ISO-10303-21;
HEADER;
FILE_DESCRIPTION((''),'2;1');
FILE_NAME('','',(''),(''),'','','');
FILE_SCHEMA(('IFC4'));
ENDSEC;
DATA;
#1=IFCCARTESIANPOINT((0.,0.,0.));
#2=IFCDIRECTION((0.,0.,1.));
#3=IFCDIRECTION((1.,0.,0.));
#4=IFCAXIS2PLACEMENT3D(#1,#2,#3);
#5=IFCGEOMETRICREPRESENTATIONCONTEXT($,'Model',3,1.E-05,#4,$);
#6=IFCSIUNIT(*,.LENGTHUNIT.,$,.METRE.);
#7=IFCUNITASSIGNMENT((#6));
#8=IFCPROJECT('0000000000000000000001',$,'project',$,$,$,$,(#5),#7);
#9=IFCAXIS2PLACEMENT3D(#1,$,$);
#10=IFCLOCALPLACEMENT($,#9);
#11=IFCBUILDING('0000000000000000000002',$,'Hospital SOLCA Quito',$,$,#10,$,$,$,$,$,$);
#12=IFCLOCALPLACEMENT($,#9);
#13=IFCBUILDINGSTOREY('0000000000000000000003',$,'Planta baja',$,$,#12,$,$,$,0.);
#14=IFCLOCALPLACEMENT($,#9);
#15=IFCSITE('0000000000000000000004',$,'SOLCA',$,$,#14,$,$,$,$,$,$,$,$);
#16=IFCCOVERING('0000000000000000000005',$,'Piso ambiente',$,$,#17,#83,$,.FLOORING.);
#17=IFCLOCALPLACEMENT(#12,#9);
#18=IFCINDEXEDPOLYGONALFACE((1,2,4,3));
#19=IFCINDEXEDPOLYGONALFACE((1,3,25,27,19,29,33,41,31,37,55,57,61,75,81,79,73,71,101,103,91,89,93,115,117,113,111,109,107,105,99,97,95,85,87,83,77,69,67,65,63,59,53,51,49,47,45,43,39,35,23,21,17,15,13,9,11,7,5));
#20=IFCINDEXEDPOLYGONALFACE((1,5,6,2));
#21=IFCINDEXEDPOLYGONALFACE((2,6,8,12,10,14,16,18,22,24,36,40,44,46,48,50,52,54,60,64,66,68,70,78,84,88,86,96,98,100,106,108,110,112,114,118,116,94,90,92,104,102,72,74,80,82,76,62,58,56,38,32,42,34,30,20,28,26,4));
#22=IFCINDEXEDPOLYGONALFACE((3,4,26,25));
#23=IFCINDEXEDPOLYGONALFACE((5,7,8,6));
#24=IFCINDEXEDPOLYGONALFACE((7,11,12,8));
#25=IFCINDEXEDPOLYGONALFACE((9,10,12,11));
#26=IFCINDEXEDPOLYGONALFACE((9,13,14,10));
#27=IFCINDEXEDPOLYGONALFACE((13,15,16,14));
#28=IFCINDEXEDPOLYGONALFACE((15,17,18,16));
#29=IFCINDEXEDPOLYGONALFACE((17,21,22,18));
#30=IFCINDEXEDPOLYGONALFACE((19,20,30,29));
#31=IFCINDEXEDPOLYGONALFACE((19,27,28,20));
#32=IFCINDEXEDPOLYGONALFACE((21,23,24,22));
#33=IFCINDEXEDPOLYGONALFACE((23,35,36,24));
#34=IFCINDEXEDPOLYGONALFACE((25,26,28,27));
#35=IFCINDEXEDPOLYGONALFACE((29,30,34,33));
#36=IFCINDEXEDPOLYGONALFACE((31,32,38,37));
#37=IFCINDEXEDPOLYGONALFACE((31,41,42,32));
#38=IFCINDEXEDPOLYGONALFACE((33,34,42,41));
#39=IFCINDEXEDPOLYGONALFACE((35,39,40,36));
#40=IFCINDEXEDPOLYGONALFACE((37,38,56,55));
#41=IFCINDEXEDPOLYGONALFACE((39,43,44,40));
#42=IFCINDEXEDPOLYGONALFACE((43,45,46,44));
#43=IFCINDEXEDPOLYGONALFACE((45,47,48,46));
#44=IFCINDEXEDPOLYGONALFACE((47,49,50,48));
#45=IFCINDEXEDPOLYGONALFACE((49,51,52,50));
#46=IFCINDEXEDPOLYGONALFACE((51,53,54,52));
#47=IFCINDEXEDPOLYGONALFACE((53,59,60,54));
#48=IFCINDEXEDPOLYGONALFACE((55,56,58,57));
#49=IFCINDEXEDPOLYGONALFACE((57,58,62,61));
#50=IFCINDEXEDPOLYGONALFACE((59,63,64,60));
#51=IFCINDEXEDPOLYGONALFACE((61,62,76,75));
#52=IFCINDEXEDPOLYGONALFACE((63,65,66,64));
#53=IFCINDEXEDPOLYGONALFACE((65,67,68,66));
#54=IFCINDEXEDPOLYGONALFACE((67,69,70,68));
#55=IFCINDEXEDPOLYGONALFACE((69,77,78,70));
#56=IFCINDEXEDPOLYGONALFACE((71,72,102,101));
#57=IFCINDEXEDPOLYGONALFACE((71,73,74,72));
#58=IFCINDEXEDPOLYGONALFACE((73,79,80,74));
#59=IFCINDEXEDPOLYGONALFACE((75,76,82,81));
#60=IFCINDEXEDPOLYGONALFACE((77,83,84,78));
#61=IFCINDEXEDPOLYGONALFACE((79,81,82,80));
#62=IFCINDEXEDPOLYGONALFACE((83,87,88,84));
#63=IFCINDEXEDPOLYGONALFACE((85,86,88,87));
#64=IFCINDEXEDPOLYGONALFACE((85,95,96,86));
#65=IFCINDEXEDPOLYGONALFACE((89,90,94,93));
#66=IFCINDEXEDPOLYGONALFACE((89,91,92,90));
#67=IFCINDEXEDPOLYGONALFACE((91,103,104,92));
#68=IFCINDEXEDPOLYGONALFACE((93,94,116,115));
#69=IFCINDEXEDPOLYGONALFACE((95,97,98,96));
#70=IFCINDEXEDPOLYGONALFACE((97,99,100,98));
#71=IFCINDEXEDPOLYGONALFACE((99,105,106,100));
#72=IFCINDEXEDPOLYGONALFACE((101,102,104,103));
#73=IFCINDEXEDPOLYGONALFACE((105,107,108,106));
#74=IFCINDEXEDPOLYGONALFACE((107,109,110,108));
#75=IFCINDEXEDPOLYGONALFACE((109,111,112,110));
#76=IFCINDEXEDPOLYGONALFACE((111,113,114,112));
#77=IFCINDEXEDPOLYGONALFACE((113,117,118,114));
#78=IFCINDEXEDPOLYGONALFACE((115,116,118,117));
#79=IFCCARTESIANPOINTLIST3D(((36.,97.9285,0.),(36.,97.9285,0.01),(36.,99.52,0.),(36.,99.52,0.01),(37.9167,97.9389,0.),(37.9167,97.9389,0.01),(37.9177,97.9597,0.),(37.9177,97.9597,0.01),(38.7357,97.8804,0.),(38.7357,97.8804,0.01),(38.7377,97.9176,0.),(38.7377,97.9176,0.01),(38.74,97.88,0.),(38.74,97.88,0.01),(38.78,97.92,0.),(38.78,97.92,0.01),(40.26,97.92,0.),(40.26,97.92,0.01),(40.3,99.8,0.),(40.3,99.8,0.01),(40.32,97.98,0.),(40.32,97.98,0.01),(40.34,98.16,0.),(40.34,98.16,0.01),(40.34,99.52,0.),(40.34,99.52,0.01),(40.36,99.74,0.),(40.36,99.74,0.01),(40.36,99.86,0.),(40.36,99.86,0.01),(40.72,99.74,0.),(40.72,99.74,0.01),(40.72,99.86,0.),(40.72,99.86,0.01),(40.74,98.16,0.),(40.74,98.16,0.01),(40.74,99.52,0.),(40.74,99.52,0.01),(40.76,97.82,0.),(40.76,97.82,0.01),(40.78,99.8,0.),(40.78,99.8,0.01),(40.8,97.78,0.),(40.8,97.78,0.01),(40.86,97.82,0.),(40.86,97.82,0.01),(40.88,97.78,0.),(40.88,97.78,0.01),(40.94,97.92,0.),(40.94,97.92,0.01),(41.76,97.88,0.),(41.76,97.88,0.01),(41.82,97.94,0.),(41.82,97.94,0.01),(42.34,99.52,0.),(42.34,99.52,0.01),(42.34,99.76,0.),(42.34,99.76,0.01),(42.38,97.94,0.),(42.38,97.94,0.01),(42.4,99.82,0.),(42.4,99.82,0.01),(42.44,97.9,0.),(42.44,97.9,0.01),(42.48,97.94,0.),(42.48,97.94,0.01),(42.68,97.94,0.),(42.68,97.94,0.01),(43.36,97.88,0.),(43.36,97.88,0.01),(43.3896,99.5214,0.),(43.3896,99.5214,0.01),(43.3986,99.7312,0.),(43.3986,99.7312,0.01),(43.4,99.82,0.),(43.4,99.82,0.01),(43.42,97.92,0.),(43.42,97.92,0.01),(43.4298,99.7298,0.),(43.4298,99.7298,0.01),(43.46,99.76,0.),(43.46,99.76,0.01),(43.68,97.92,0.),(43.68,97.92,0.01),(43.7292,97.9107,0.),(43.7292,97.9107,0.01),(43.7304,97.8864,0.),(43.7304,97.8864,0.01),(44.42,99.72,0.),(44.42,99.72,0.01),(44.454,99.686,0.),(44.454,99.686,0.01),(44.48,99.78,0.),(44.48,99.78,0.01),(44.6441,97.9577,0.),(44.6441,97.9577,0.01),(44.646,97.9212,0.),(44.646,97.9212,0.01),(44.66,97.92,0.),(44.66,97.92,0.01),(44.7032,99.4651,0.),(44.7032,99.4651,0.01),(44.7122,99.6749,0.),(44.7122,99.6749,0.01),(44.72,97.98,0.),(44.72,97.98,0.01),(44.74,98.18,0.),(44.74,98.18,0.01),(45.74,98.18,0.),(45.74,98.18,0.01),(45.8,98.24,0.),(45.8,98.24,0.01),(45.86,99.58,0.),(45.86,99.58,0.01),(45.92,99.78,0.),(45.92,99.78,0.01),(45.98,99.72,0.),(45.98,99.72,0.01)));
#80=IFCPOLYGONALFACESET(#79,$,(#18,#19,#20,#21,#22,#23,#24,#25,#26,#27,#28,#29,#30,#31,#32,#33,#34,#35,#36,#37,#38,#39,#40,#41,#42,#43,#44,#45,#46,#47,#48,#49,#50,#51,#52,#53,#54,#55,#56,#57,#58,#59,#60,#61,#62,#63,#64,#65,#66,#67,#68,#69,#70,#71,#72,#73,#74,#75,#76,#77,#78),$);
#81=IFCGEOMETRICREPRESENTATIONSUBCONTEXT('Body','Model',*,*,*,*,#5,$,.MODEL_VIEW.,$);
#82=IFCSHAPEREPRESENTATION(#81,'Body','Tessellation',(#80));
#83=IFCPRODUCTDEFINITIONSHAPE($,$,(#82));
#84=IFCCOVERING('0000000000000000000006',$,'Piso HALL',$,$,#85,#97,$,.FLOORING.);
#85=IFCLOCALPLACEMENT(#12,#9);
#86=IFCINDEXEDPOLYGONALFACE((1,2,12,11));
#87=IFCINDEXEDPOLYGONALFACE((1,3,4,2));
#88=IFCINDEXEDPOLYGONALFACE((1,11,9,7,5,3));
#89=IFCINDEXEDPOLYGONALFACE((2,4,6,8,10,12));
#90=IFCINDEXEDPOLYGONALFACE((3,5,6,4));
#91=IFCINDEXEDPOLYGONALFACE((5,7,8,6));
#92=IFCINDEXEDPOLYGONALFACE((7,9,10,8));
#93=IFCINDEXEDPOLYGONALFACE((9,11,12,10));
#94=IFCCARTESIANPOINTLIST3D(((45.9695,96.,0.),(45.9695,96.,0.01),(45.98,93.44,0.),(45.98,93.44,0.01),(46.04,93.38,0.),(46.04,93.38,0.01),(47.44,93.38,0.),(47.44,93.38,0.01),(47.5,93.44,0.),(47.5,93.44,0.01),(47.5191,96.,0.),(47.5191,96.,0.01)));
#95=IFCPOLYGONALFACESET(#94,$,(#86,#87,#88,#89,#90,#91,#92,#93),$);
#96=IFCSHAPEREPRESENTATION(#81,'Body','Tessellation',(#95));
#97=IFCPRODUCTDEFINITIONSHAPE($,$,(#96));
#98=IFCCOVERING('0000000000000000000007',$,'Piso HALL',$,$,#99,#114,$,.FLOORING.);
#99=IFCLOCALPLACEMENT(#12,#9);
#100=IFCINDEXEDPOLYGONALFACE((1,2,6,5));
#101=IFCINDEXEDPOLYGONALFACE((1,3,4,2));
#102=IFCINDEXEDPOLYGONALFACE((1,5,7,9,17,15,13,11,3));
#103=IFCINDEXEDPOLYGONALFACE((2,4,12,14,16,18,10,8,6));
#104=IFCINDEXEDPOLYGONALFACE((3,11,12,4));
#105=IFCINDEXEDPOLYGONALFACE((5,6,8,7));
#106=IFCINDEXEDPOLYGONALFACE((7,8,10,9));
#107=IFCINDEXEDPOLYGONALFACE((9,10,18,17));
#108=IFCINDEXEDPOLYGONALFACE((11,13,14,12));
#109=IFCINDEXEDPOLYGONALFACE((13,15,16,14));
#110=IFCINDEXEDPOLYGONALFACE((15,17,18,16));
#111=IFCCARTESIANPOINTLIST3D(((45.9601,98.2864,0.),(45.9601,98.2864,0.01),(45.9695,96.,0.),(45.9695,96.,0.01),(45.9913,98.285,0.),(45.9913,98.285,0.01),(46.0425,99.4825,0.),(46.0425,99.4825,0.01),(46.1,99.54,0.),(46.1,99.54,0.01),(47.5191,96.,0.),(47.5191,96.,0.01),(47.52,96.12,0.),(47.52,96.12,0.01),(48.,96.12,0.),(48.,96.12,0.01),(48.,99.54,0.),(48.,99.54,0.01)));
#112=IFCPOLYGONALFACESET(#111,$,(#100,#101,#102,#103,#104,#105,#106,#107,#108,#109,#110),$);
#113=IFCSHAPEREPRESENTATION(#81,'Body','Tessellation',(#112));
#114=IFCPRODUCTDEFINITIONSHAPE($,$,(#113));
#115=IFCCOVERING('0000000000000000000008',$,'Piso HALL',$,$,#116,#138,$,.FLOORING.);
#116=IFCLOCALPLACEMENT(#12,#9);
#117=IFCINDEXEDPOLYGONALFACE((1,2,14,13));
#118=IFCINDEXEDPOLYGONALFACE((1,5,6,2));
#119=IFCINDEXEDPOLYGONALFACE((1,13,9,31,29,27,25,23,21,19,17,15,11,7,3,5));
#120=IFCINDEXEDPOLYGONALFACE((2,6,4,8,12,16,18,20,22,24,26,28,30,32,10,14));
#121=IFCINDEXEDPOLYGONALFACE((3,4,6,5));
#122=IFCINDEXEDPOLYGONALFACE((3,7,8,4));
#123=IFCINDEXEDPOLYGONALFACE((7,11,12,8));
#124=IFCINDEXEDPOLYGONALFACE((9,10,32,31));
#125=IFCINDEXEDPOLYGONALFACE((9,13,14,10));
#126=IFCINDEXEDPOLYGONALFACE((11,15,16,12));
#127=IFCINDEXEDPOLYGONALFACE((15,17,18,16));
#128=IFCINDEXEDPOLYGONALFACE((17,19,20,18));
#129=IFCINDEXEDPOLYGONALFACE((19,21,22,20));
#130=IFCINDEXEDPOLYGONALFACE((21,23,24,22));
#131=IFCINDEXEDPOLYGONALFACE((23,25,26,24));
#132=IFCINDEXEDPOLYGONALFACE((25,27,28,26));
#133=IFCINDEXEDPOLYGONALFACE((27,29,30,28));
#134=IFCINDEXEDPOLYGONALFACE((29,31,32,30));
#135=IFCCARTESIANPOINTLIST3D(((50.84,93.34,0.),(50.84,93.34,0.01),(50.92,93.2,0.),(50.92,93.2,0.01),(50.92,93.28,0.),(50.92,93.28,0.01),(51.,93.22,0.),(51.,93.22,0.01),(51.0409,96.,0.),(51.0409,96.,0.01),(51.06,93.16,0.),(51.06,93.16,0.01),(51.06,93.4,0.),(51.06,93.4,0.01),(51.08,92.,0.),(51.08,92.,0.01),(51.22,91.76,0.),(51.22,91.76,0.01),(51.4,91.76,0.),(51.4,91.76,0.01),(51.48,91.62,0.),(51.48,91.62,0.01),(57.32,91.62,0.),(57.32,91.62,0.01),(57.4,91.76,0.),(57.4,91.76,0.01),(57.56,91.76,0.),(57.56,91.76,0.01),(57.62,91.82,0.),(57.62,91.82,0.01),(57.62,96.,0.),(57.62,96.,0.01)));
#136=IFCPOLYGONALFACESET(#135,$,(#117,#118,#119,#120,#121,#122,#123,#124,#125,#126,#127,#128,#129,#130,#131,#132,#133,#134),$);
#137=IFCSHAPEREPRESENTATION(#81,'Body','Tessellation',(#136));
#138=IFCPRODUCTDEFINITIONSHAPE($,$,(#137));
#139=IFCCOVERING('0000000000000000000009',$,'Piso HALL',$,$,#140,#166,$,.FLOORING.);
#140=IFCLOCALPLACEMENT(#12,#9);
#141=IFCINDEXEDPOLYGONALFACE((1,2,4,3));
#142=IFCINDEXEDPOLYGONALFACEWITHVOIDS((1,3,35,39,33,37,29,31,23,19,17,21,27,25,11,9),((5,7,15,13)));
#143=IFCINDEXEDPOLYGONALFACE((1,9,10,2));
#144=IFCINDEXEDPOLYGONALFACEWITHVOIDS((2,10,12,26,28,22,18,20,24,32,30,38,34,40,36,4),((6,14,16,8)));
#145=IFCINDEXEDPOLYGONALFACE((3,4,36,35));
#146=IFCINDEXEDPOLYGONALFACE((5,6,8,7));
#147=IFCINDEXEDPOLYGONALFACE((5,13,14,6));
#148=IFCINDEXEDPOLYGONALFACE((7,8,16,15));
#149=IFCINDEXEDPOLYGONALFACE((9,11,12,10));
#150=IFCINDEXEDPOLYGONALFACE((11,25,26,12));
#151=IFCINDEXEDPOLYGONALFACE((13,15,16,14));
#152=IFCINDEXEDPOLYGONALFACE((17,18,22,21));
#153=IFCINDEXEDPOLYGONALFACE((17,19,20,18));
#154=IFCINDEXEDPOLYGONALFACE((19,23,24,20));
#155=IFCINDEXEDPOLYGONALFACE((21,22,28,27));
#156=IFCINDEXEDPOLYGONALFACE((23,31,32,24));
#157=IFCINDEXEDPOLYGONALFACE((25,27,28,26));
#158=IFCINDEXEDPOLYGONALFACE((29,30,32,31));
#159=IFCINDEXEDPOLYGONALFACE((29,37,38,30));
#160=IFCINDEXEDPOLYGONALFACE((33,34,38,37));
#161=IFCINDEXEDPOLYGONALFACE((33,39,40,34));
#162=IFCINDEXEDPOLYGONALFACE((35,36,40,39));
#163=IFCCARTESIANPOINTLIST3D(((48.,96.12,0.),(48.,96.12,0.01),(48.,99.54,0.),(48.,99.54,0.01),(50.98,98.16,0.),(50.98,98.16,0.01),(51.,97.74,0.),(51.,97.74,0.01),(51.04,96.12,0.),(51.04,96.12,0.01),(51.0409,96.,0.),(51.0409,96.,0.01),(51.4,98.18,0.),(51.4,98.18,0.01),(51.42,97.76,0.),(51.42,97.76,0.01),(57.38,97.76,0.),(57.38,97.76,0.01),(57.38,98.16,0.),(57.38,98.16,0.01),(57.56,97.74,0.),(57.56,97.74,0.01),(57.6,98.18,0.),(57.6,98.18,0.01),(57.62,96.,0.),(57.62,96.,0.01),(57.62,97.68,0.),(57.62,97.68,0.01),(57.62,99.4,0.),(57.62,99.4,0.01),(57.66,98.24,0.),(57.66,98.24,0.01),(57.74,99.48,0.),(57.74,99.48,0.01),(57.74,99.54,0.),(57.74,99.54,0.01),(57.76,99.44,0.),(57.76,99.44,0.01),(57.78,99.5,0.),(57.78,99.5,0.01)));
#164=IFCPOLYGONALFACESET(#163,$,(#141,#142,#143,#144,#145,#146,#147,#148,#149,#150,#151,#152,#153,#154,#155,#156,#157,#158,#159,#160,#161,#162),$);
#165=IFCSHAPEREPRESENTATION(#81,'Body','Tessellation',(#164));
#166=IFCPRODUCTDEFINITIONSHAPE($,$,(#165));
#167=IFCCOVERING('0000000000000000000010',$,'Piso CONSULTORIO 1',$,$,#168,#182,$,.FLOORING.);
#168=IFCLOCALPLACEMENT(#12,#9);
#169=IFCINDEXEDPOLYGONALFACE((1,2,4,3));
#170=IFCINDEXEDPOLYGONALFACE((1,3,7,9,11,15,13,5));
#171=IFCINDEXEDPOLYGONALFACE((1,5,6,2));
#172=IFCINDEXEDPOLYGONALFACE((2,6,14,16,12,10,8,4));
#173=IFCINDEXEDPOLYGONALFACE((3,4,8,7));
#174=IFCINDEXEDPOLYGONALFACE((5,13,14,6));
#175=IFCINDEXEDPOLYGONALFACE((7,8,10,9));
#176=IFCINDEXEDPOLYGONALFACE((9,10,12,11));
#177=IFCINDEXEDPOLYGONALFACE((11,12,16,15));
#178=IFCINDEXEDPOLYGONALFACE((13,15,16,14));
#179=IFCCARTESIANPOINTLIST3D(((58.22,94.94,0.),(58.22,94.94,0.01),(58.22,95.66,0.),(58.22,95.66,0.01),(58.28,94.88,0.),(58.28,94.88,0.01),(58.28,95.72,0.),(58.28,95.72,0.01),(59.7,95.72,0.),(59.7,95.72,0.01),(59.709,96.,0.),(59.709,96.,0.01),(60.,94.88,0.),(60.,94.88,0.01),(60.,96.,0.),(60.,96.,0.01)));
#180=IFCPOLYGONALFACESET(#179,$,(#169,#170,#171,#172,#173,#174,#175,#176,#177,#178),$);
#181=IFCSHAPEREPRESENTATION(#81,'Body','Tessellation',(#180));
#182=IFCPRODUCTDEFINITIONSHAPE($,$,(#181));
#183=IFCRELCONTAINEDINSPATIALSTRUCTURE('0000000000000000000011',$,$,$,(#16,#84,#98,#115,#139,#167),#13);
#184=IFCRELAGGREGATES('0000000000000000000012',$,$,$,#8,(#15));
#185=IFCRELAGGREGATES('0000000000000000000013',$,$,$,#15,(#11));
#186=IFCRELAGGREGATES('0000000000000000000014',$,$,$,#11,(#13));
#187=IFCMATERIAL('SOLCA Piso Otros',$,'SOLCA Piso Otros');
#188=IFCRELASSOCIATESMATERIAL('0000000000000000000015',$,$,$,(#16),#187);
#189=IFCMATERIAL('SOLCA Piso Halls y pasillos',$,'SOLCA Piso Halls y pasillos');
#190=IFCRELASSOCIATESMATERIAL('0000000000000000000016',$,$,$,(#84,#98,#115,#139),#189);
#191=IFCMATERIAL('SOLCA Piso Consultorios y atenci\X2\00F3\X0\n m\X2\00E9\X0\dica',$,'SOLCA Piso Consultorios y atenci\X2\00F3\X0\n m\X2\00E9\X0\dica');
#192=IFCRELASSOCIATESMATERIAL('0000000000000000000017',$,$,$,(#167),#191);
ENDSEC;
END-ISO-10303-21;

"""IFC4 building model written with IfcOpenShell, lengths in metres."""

from ifc_helpers import new_model, si_unit, origin, origin_with_axes, place, context, subcontext, project, spatial, polyline, outline, extrude, material, element, save


model = new_model("IFC4")

# Units and contexts
model_context = context("Model", 3, precision=1e-05, world=origin_with_axes())
body_context = subcontext(model_context, "Body", "Model", "MODEL_VIEW")
ifc_project = project(units=[si_unit("LENGTHUNIT", "METRE")], contexts=[model_context])

# Site, building, storey
site_placement = place(None, origin())
site = spatial("IfcSite", under=ifc_project, at=site_placement, Name="SOLCA")
building_placement = place(None, origin())
building = spatial("IfcBuilding", under=site, at=building_placement, Name="Hospital SOLCA Quito")
storey_placement = place(None, origin())
storey = spatial("IfcBuildingStorey", under=building, at=storey_placement, Name="Planta baja", Elevation=0.0)

# Coverings
ifc_material_1 = material(Name="SOLCA Piso Otros", Category="SOLCA Piso Otros")
covering_1_placement = place(storey_placement, origin_with_axes())
element("IfcCovering", 1, at=covering_1_placement, inside=storey, material=ifc_material_1, Name="Piso ambiente", PredefinedType="FLOORING", context=body_context, shape_type="SweptSolid", body=[
    extrude(outline(polyline([(40.34, 99.52), (40.36, 99.74), (40.3, 99.8), (40.36, 99.86), (40.72, 99.86), (40.78, 99.8), (40.72, 99.74), (40.74, 99.52), (42.34, 99.52), (42.34, 99.76), (42.4, 99.82), (43.4, 99.82), (43.46, 99.76), (43.4298, 99.7298), (43.3986, 99.7312), (43.3896, 99.5214), (44.7032, 99.4651), (44.7122, 99.6749), (44.454, 99.686), (44.42, 99.72), (44.48, 99.78), (45.92, 99.78), (45.98, 99.72), (45.86, 99.58), (45.8, 98.24), (45.74, 98.18), (44.74, 98.18), (44.72, 97.98), (44.66, 97.92), (44.646, 97.9212), (44.6441, 97.9577), (43.7292, 97.9107), (43.7304, 97.8864), (43.68, 97.92), (43.42, 97.92), (43.36, 97.88), (42.68, 97.94), (42.48, 97.94), (42.44, 97.9), (42.38, 97.94), (41.82, 97.94), (41.76, 97.88), (40.94, 97.92), (40.88, 97.78), (40.86, 97.82), (40.8, 97.78), (40.76, 97.82), (40.74, 98.16), (40.34, 98.16), (40.32, 97.98), (40.26, 97.92), (38.78, 97.92), (38.74, 97.88), (38.7357, 97.8804), (38.7377, 97.9176), (37.9177, 97.9597), (37.9167, 97.9389), (36.0, 97.9285), (36.0, 99.52), (40.34, 99.52)])), origin_with_axes(), (0.0, 0.0, 1.0), 0.01),
])
ifc_material_2 = material(Name="SOLCA Piso Halls y pasillos", Category="SOLCA Piso Halls y pasillos")
covering_2_placement = place(storey_placement, origin_with_axes())
element("IfcCovering", 2, at=covering_2_placement, inside=storey, material=ifc_material_2, Name="Piso HALL", PredefinedType="FLOORING", context=body_context, shape_type="SweptSolid", body=[
    extrude(outline(polyline([(47.5, 93.44), (47.44, 93.38), (46.04, 93.38), (45.98, 93.44), (45.9695, 96.0), (47.5191, 96.0), (47.5, 93.44)])), origin_with_axes(), (0.0, 0.0, 1.0), 0.01),
])
covering_3_placement = place(storey_placement, origin_with_axes())
element("IfcCovering", 3, at=covering_3_placement, inside=storey, material=ifc_material_2, Name="Piso HALL", PredefinedType="FLOORING", context=body_context, shape_type="SweptSolid", body=[
    extrude(outline(polyline([(47.52, 96.12), (47.5191, 96.0), (45.9695, 96.0), (45.9601, 98.2864), (45.9913, 98.285), (46.0425, 99.4825), (46.1, 99.54), (48.0, 99.54), (48.0, 96.12), (47.52, 96.12)])), origin_with_axes(), (0.0, 0.0, 1.0), 0.01),
])
covering_4_placement = place(storey_placement, origin_with_axes())
element("IfcCovering", 4, at=covering_4_placement, inside=storey, material=ifc_material_2, Name="Piso HALL", PredefinedType="FLOORING", context=body_context, shape_type="SweptSolid", body=[
    extrude(outline(polyline([(57.62, 91.82), (57.56, 91.76), (57.4, 91.76), (57.32, 91.62), (51.48, 91.62), (51.4, 91.76), (51.22, 91.76), (51.08, 92.0), (51.06, 93.16), (51.0, 93.22), (50.92, 93.2), (50.92, 93.28), (50.84, 93.34), (51.06, 93.4), (51.0409, 96.0), (57.62, 96.0), (57.62, 91.82)])), origin_with_axes(), (0.0, 0.0, 1.0), 0.01),
])
covering_5_placement = place(storey_placement, origin_with_axes())
element("IfcCovering", 5, at=covering_5_placement, inside=storey, material=ifc_material_2, Name="Piso HALL", PredefinedType="FLOORING", context=body_context, shape_type="SweptSolid", body=[
    extrude(outline(polyline([(57.78, 99.5), (57.74, 99.48), (57.76, 99.44), (57.62, 99.4), (57.66, 98.24), (57.6, 98.18), (57.38, 98.16), (57.38, 97.76), (57.56, 97.74), (57.62, 97.68), (57.62, 96.0), (51.0409, 96.0), (51.04, 96.12), (48.0, 96.12), (48.0, 99.54), (57.74, 99.54), (57.78, 99.5)]), holes=[polyline([(51.42, 97.76), (51.4, 98.18), (50.98, 98.16), (51.0, 97.74), (51.42, 97.76)])]), origin_with_axes(), (0.0, 0.0, 1.0), 0.01),
])
ifc_material_3 = material(Name="SOLCA Piso Consultorios y atención médica", Category="SOLCA Piso Consultorios y atención médica")
covering_6_placement = place(storey_placement, origin_with_axes())
element("IfcCovering", 6, at=covering_6_placement, inside=storey, material=ifc_material_3, Name="Piso CONSULTORIO 1", PredefinedType="FLOORING", context=body_context, shape_type="SweptSolid", body=[
    extrude(outline(polyline([(58.28, 94.88), (58.22, 94.94), (58.22, 95.66), (58.28, 95.72), (59.7, 95.72), (59.709, 96.0), (60.0, 96.0), (60.0, 94.88), (58.28, 94.88)])), origin_with_axes(), (0.0, 0.0, 1.0), 0.01),
])

save(model, "model.ifc")
